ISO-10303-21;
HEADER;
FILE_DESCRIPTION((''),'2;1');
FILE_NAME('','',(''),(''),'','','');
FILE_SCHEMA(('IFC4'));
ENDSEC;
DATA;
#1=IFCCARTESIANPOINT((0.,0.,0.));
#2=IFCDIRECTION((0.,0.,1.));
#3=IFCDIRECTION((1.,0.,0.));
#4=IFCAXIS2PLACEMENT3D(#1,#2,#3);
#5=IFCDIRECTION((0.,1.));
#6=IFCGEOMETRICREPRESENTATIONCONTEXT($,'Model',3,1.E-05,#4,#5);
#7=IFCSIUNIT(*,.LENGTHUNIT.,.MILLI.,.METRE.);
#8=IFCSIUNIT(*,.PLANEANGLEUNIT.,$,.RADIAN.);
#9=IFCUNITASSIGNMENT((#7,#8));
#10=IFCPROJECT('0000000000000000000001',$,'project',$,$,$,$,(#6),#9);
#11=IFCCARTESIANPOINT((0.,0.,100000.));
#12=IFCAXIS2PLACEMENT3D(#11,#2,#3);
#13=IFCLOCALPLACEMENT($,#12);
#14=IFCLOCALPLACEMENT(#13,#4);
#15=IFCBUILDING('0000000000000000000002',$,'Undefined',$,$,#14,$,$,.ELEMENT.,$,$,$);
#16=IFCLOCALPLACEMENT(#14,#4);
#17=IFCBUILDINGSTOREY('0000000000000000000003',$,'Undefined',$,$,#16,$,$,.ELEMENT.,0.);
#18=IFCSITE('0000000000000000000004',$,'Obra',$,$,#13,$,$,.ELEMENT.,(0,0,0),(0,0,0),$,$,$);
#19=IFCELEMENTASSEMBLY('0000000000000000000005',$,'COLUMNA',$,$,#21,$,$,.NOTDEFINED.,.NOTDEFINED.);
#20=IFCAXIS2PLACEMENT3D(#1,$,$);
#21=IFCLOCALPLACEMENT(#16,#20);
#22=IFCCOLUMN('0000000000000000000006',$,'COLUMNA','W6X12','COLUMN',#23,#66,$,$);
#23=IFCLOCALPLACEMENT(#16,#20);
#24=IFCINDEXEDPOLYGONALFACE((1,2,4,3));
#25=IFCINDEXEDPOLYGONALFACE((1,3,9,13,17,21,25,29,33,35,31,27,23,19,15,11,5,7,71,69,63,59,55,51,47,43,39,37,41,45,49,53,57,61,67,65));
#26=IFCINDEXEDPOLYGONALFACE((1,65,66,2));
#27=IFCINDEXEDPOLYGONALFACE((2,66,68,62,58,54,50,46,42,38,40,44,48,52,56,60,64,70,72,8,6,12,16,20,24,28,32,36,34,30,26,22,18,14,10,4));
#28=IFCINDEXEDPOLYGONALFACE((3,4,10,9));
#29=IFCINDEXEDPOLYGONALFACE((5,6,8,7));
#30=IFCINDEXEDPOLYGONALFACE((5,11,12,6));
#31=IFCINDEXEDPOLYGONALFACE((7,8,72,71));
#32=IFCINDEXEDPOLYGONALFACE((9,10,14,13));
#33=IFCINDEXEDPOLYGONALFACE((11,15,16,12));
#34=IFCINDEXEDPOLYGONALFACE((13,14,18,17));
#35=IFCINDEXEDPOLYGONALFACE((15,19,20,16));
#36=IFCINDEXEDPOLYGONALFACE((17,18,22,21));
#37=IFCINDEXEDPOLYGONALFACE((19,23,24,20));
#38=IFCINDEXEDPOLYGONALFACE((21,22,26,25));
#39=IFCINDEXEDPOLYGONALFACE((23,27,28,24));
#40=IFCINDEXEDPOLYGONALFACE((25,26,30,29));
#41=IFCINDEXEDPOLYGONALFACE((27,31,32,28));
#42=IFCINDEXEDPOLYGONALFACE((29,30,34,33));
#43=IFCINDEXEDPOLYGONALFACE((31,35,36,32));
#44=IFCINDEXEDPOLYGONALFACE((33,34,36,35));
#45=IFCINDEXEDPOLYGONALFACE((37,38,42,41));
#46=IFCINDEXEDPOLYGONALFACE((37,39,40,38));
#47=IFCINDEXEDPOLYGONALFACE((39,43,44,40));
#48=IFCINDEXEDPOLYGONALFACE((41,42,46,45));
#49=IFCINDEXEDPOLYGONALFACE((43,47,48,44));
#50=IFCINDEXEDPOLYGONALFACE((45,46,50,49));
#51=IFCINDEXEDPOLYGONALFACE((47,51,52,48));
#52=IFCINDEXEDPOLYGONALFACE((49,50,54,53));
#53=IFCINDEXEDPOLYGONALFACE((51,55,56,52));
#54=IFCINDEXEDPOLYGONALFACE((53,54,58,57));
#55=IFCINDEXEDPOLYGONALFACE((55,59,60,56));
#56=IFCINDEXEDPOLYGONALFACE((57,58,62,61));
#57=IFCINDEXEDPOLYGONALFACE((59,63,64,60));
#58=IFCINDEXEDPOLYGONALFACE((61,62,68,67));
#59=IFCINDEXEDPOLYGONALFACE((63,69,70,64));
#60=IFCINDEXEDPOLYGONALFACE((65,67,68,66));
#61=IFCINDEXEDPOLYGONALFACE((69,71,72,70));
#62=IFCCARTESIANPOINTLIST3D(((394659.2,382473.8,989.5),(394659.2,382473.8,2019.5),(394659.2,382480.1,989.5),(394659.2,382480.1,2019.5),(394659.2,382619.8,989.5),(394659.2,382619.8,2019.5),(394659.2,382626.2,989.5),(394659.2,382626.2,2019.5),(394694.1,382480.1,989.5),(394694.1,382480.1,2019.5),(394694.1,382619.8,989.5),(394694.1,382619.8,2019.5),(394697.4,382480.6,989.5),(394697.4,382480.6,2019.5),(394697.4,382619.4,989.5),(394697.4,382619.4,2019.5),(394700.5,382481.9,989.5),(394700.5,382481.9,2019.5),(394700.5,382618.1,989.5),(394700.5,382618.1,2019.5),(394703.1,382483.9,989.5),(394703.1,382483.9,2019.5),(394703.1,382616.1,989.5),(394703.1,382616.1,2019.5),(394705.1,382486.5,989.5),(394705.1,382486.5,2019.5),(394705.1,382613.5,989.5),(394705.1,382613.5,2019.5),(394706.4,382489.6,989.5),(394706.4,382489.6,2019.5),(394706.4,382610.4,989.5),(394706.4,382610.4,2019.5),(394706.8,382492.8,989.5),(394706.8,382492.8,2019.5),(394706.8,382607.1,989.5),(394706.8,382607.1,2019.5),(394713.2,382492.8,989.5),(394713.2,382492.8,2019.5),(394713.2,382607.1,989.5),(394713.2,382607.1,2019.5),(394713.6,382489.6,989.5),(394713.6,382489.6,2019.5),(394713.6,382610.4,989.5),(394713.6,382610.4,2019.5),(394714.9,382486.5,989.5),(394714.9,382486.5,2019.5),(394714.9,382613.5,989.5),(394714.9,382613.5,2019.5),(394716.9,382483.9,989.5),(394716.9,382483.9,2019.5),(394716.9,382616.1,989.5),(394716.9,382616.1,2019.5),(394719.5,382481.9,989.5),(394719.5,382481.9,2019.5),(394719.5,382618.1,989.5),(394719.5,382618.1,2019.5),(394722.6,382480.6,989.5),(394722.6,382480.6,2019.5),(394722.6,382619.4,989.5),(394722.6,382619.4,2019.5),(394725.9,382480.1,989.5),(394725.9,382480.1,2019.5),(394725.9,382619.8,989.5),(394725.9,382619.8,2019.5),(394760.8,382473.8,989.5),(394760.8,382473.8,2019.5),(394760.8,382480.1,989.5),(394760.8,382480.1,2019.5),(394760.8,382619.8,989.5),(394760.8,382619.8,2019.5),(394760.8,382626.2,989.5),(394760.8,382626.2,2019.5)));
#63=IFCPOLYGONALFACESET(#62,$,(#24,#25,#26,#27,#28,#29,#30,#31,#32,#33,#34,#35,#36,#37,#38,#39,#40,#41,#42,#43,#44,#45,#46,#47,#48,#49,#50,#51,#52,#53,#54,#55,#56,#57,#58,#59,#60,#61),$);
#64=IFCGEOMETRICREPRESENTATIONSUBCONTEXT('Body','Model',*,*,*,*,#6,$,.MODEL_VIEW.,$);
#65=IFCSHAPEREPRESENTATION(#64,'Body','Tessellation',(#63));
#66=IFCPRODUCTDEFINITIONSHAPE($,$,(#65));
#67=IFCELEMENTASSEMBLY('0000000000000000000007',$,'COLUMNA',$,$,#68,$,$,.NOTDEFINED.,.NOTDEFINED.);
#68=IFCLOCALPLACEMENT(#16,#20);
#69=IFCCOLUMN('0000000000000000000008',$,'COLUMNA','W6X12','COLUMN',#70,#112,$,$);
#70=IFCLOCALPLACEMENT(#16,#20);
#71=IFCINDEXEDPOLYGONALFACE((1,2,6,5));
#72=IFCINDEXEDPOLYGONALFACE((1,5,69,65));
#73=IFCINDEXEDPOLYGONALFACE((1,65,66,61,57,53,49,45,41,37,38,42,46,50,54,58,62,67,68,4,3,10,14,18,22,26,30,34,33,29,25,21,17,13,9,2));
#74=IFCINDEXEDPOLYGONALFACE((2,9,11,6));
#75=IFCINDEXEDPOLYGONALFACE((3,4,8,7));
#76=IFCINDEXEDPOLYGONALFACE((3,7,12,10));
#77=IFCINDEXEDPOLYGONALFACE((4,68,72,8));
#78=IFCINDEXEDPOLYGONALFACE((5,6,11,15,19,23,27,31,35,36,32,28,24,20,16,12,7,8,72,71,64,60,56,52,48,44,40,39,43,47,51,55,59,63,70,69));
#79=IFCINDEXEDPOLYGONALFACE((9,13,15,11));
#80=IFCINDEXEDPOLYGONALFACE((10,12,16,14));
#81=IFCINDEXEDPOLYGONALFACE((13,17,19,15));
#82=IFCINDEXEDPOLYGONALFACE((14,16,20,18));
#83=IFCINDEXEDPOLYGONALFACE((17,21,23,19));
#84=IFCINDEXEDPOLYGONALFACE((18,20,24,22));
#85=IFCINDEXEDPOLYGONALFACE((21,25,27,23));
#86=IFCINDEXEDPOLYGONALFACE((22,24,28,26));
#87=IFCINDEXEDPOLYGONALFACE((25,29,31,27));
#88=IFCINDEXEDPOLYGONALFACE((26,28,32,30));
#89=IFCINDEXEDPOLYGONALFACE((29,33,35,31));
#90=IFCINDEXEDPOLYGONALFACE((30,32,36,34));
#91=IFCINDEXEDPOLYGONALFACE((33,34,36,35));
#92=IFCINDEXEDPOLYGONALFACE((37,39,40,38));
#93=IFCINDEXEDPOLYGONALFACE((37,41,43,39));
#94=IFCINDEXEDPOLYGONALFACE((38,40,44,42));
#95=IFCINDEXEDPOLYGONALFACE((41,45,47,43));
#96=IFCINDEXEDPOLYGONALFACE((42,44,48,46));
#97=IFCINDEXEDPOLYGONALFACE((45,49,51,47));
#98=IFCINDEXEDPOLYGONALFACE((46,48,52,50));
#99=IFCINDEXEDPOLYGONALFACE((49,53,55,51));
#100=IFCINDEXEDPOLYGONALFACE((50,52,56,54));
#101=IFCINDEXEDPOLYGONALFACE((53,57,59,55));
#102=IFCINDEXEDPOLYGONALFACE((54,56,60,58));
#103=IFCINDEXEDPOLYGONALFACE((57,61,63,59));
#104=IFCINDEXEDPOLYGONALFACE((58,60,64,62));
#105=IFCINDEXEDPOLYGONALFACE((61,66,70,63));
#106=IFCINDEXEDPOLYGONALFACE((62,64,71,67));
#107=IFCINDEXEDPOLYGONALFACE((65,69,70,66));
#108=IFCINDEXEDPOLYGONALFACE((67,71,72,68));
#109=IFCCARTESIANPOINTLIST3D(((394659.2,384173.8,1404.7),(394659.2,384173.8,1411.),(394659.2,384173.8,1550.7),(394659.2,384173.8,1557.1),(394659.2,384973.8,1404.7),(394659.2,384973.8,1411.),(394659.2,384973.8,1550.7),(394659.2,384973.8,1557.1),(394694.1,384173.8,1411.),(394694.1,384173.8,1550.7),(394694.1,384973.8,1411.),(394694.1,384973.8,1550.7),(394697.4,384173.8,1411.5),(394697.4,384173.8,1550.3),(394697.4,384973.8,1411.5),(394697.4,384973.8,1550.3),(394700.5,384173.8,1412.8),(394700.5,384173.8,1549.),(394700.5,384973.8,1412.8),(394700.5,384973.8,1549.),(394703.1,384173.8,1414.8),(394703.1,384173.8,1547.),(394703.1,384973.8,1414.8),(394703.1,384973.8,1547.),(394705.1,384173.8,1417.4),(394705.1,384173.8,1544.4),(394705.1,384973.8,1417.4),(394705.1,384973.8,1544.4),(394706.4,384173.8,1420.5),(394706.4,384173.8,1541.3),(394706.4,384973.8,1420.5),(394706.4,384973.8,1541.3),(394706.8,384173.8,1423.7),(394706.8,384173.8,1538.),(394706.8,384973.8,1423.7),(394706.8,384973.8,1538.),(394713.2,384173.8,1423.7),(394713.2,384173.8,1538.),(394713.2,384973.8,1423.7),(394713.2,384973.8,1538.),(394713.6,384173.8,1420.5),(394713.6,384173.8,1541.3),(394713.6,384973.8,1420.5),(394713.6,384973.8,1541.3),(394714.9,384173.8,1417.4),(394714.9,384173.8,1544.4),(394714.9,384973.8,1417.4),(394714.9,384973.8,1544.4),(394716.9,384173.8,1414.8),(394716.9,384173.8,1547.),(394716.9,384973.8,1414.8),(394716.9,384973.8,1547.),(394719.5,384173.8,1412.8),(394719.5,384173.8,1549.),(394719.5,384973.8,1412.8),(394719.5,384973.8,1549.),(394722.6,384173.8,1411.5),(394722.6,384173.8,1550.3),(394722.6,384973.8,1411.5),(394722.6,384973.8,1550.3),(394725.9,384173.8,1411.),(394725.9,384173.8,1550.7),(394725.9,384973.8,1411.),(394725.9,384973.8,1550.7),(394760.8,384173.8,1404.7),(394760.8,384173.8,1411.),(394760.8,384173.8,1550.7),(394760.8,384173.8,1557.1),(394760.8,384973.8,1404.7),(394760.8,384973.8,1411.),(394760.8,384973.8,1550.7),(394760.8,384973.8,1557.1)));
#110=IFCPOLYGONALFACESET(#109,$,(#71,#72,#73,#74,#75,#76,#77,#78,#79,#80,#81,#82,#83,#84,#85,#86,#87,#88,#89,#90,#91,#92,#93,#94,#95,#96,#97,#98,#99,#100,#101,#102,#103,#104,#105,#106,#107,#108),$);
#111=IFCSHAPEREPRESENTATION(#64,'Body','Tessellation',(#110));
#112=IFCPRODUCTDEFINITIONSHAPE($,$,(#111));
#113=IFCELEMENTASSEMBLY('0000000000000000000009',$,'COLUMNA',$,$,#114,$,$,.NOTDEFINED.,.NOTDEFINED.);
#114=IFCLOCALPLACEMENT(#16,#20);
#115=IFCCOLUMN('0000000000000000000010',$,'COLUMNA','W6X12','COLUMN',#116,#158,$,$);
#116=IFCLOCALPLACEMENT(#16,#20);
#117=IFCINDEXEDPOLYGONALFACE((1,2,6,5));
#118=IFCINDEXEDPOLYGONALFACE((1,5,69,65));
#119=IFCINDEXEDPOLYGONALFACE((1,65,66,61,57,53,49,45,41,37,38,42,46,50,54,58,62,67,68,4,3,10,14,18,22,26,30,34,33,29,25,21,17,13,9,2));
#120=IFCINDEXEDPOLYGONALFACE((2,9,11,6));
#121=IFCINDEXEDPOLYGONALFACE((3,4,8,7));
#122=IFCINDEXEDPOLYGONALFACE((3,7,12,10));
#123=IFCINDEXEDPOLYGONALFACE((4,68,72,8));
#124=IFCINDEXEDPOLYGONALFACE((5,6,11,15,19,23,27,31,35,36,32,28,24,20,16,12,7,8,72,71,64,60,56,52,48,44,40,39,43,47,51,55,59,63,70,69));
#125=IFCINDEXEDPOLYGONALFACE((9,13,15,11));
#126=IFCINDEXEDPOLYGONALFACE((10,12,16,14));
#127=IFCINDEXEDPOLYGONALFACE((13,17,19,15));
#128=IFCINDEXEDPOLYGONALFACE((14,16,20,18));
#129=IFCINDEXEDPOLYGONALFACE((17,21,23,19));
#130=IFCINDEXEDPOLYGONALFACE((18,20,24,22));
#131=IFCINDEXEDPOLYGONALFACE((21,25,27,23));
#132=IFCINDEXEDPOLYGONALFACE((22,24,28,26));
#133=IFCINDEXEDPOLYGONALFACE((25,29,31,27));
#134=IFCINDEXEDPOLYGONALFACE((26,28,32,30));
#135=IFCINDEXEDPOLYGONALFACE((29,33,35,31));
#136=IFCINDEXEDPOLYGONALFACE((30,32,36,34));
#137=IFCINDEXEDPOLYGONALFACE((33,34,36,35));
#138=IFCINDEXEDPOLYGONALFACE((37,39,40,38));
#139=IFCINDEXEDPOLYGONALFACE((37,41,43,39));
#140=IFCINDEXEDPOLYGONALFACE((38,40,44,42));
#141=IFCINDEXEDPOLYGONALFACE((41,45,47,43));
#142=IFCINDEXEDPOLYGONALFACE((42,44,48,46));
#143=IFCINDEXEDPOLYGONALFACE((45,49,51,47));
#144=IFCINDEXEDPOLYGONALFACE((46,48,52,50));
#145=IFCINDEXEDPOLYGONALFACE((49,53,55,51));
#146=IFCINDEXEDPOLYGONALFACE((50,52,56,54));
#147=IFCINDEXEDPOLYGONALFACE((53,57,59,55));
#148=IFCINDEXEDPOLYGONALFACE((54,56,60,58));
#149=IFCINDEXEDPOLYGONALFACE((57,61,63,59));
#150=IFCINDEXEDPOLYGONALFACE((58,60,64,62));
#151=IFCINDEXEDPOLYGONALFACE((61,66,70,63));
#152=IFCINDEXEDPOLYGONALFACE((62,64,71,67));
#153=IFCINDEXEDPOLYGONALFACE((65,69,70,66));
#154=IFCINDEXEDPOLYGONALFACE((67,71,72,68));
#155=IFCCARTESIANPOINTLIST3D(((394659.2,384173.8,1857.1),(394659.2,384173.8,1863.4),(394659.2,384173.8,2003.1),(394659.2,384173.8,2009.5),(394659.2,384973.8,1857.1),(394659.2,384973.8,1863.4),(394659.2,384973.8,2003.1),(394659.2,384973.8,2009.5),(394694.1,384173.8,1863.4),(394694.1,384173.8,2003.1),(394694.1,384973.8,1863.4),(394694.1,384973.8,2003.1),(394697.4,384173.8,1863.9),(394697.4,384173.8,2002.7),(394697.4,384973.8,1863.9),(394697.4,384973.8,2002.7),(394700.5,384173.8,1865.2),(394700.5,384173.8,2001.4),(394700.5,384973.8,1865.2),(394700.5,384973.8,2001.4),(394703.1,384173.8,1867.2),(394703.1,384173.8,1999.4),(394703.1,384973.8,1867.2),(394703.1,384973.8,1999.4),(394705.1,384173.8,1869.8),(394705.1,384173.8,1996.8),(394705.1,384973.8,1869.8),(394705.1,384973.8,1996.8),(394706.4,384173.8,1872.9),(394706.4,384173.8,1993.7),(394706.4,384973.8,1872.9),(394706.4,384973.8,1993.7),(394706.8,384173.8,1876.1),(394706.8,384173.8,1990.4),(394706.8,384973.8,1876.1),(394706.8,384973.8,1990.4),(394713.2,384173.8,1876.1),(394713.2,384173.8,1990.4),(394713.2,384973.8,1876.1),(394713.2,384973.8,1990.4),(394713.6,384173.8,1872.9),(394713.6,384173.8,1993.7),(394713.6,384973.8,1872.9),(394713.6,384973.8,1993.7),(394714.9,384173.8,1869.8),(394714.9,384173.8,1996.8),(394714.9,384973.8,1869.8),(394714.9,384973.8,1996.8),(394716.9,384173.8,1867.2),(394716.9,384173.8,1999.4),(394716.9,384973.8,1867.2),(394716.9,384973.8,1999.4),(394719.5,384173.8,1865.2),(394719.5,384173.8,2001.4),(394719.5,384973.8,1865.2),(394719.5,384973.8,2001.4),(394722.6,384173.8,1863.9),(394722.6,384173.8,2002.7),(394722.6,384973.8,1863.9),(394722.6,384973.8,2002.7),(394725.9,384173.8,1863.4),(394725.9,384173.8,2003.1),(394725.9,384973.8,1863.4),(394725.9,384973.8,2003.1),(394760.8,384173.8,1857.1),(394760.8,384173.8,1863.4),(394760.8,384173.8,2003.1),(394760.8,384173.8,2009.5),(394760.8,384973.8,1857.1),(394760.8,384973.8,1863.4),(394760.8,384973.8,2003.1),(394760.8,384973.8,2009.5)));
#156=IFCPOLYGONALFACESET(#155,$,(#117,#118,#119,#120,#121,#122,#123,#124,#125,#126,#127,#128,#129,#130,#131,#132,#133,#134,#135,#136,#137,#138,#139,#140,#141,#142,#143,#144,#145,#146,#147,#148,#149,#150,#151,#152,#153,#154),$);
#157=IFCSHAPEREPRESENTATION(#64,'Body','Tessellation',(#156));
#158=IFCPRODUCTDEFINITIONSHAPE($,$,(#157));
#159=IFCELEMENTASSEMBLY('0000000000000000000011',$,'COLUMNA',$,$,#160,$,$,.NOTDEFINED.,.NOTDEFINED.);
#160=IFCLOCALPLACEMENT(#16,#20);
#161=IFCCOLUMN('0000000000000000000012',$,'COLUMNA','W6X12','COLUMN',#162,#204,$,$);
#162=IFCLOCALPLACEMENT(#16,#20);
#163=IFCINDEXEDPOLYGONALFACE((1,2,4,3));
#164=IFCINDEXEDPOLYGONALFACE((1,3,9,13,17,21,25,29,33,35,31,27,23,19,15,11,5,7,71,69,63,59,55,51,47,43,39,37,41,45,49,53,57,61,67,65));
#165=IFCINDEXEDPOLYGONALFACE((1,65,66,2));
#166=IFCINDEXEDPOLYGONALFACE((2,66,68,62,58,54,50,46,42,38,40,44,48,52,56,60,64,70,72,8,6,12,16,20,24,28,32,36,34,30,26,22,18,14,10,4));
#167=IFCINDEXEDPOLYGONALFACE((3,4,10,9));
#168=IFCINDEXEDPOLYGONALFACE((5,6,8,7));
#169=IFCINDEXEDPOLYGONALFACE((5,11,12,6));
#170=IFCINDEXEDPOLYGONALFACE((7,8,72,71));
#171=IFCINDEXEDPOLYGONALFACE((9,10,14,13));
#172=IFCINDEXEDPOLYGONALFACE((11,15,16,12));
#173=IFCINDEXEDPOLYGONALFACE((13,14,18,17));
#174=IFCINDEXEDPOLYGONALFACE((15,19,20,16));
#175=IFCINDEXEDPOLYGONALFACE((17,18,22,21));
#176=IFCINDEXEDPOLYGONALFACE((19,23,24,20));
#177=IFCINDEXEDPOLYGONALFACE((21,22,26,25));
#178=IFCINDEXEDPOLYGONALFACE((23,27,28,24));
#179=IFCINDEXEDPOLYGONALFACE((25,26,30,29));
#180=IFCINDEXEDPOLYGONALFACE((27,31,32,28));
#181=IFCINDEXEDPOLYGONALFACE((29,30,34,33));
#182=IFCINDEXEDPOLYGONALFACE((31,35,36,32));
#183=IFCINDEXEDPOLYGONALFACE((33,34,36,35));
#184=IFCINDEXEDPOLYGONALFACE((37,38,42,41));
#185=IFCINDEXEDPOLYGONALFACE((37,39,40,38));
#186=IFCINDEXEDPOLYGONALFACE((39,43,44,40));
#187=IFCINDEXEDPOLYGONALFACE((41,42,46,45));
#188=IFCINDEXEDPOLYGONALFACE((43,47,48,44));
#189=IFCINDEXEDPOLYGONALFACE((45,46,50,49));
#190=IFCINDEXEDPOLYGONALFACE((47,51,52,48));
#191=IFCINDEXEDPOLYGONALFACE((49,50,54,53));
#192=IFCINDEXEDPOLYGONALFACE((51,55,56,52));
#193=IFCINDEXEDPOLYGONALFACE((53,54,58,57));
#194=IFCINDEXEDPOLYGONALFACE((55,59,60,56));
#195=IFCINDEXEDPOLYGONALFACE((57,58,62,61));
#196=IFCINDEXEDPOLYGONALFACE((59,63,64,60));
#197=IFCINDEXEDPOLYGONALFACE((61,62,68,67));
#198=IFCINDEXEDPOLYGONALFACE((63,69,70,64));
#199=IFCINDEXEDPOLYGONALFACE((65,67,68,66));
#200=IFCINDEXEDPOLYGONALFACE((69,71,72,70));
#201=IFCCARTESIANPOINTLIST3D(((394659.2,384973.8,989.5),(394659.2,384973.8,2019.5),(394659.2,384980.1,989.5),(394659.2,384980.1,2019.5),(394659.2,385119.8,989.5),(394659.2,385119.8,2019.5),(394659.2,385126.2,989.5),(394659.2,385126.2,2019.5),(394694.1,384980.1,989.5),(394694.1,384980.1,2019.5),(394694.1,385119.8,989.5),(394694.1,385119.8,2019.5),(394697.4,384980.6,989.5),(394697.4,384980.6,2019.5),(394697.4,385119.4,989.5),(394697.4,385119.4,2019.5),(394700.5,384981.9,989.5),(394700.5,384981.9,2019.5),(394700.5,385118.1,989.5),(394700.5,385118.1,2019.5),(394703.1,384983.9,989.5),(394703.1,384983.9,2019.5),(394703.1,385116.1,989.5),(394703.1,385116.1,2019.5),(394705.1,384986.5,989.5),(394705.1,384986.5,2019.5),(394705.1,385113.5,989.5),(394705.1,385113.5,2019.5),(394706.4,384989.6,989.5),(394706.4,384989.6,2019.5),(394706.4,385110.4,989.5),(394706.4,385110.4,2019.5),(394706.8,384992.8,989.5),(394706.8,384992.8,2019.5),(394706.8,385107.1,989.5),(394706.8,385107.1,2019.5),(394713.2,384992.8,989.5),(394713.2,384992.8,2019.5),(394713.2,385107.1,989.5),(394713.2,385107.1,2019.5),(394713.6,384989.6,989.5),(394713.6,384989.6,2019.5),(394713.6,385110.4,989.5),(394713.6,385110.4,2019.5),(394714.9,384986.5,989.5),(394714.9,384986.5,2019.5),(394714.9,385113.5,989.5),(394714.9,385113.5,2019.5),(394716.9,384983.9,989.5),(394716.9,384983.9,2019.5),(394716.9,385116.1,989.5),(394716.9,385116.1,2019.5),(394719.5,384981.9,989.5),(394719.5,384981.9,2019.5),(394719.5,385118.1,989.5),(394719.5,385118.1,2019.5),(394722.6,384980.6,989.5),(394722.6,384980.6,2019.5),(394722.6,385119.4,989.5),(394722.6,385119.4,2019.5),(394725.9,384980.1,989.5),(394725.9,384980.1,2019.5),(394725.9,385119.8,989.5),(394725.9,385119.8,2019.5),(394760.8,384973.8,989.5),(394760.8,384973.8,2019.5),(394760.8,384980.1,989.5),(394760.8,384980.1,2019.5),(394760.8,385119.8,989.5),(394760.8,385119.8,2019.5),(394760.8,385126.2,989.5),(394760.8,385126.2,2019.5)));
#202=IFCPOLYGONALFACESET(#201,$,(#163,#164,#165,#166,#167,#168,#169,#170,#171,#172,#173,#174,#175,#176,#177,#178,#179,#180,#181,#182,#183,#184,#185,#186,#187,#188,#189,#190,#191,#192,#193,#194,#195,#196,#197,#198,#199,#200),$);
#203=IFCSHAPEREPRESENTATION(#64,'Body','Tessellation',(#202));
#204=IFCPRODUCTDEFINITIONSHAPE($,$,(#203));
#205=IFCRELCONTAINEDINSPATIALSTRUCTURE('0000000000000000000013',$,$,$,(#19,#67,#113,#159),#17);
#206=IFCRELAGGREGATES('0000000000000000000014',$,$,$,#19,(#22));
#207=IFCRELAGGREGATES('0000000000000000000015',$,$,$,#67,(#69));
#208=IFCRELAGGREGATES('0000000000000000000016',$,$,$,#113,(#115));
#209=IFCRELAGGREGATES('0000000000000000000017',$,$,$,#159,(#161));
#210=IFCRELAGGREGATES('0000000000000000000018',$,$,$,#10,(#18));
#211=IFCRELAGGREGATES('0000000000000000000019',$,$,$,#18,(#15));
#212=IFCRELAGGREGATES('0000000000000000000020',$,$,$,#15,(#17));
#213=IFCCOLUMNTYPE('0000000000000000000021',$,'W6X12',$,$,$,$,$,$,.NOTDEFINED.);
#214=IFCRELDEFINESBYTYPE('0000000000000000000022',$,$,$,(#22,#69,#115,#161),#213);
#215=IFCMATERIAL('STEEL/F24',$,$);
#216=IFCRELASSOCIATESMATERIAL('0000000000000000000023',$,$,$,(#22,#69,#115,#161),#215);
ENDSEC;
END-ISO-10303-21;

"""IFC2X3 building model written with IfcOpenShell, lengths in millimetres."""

from ifc_helpers import new_model, si_unit, direction, frame, origin_with_axes, origin_2d_with_axis, place, context, subcontext, project, spatial, i_section, extrude, material, type_object, element, aggregate, save


model = new_model("IFC2X3")

# Units and contexts
model_context = context("Model", 3, precision=1e-05, world=origin_with_axes(), true_north=direction((0.0, 1.0)))
body_context = subcontext(model_context, "Body", "Model", "MODEL_VIEW")
ifc_project = project(units=[si_unit("LENGTHUNIT", "METRE", prefix="MILLI"), si_unit("PLANEANGLEUNIT", "RADIAN")], contexts=[model_context])

# Site, building, storey
site_placement = place(None, frame((0.0, 0.0, 100000.0), z_axis=(0.0, 0.0, 1.0), x_axis=(1.0, 0.0, 0.0)))
site = spatial("IfcSite", under=ifc_project, at=site_placement, Name="Obra", CompositionType="ELEMENT", RefLatitude=(0, 0, 0), RefLongitude=(0, 0, 0))
building_placement = place(site_placement, origin_with_axes())
building = spatial("IfcBuilding", under=site, at=building_placement, Name="Undefined", CompositionType="ELEMENT")
storey_placement = place(building_placement, origin_with_axes())
storey = spatial("IfcBuildingStorey", under=building, at=storey_placement, Name="Undefined", CompositionType="ELEMENT", Elevation=0.0)

# Element assemblies, columns
ifc_material_1 = material(Name="STEEL/F24")
column_type_1 = type_object("IfcColumnType", Name="W6X12", PredefinedType="NOTDEFINED")
assembly_1_placement = place(storey_placement, origin_with_axes())
assembly_1 = element("IfcElementAssembly", 1, at=assembly_1_placement, inside=storey, Name="COLUMNA", AssemblyPlace="NOTDEFINED", PredefinedType="NOTDEFINED")
column_1_placement = place(assembly_1_placement, frame((394710.0, 382550.0, 989.5), z_axis=(0.0, 0.0, 1.0), x_axis=(0.0, -1.0, 0.0)))
column_1 = element("IfcColumn", 2, at=column_1_placement, type_object=column_type_1, material=ifc_material_1, Name="COLUMNA", Description="W6X12", ObjectType="COLUMN", context=body_context, shape_type="SweptSolid", body=[
    extrude(i_section(OverallWidth=101.6, OverallDepth=152.4, WebThickness=6.3, FlangeThickness=6.3, FilletRadius=12.7, at=origin_2d_with_axis()), frame((0.0, 0.0, 1030.0), z_axis=(0.0, 0.0, -1.0), x_axis=(0.0, 1.0, 0.0)), (0.0, 0.0, 1.0), 1030.0),
])
aggregate(assembly_1, [column_1])
assembly_2_placement = place(storey_placement, origin_with_axes())
assembly_2 = element("IfcElementAssembly", 3, at=assembly_2_placement, inside=storey, Name="COLUMNA", AssemblyPlace="NOTDEFINED", PredefinedType="NOTDEFINED")
column_2_placement = place(assembly_2_placement, frame((394710.0, 384973.8, 1480.9), z_axis=(0.0, -1.0, 0.0), x_axis=(0.0, 0.0, -1.0)))
column_2 = element("IfcColumn", 4, at=column_2_placement, type_object=column_type_1, material=ifc_material_1, Name="COLUMNA", Description="W6X12", ObjectType="COLUMN", context=body_context, shape_type="SweptSolid", body=[
    extrude(i_section(OverallWidth=101.6, OverallDepth=152.4, WebThickness=6.3, FlangeThickness=6.3, FilletRadius=12.7, at=origin_2d_with_axis()), frame((0.0, 0.0, 800.0), z_axis=(0.0, 0.0, -1.0), x_axis=(0.0, 1.0, 0.0)), (0.0, 0.0, 1.0), 800.0),
])
aggregate(assembly_2, [column_2])
assembly_3_placement = place(storey_placement, origin_with_axes())
assembly_3 = element("IfcElementAssembly", 5, at=assembly_3_placement, inside=storey, Name="COLUMNA", AssemblyPlace="NOTDEFINED", PredefinedType="NOTDEFINED")
column_3_placement = place(assembly_3_placement, frame((394710.0, 384973.8, 1933.3), z_axis=(0.0, -1.0, 0.0), x_axis=(0.0, 0.0, -1.0)))
column_3 = element("IfcColumn", 6, at=column_3_placement, type_object=column_type_1, material=ifc_material_1, Name="COLUMNA", Description="W6X12", ObjectType="COLUMN", context=body_context, shape_type="SweptSolid", body=[
    extrude(i_section(OverallWidth=101.6, OverallDepth=152.4, WebThickness=6.3, FlangeThickness=6.3, FilletRadius=12.7, at=origin_2d_with_axis()), frame((0.0, 0.0, 800.0), z_axis=(0.0, 0.0, -1.0), x_axis=(0.0, 1.0, 0.0)), (0.0, 0.0, 1.0), 800.0),
])
aggregate(assembly_3, [column_3])
assembly_4_placement = place(storey_placement, origin_with_axes())
assembly_4 = element("IfcElementAssembly", 7, at=assembly_4_placement, inside=storey, Name="COLUMNA", AssemblyPlace="NOTDEFINED", PredefinedType="NOTDEFINED")
column_4_placement = place(assembly_4_placement, frame((394710.0, 385050.0, 989.5), z_axis=(0.0, 0.0, 1.0), x_axis=(0.0, 1.0, 0.0)))
column_4 = element("IfcColumn", 8, at=column_4_placement, type_object=column_type_1, material=ifc_material_1, Name="COLUMNA", Description="W6X12", ObjectType="COLUMN", context=body_context, shape_type="SweptSolid", body=[
    extrude(i_section(OverallWidth=101.6, OverallDepth=152.4, WebThickness=6.3, FlangeThickness=6.3, FilletRadius=12.7, at=origin_2d_with_axis()), frame((0.0, 0.0, 1030.0), z_axis=(0.0, 0.0, -1.0), x_axis=(0.0, 1.0, 0.0)), (0.0, 0.0, 1.0), 1030.0),
])
aggregate(assembly_4, [column_4])

save(model, "model.ifc")
